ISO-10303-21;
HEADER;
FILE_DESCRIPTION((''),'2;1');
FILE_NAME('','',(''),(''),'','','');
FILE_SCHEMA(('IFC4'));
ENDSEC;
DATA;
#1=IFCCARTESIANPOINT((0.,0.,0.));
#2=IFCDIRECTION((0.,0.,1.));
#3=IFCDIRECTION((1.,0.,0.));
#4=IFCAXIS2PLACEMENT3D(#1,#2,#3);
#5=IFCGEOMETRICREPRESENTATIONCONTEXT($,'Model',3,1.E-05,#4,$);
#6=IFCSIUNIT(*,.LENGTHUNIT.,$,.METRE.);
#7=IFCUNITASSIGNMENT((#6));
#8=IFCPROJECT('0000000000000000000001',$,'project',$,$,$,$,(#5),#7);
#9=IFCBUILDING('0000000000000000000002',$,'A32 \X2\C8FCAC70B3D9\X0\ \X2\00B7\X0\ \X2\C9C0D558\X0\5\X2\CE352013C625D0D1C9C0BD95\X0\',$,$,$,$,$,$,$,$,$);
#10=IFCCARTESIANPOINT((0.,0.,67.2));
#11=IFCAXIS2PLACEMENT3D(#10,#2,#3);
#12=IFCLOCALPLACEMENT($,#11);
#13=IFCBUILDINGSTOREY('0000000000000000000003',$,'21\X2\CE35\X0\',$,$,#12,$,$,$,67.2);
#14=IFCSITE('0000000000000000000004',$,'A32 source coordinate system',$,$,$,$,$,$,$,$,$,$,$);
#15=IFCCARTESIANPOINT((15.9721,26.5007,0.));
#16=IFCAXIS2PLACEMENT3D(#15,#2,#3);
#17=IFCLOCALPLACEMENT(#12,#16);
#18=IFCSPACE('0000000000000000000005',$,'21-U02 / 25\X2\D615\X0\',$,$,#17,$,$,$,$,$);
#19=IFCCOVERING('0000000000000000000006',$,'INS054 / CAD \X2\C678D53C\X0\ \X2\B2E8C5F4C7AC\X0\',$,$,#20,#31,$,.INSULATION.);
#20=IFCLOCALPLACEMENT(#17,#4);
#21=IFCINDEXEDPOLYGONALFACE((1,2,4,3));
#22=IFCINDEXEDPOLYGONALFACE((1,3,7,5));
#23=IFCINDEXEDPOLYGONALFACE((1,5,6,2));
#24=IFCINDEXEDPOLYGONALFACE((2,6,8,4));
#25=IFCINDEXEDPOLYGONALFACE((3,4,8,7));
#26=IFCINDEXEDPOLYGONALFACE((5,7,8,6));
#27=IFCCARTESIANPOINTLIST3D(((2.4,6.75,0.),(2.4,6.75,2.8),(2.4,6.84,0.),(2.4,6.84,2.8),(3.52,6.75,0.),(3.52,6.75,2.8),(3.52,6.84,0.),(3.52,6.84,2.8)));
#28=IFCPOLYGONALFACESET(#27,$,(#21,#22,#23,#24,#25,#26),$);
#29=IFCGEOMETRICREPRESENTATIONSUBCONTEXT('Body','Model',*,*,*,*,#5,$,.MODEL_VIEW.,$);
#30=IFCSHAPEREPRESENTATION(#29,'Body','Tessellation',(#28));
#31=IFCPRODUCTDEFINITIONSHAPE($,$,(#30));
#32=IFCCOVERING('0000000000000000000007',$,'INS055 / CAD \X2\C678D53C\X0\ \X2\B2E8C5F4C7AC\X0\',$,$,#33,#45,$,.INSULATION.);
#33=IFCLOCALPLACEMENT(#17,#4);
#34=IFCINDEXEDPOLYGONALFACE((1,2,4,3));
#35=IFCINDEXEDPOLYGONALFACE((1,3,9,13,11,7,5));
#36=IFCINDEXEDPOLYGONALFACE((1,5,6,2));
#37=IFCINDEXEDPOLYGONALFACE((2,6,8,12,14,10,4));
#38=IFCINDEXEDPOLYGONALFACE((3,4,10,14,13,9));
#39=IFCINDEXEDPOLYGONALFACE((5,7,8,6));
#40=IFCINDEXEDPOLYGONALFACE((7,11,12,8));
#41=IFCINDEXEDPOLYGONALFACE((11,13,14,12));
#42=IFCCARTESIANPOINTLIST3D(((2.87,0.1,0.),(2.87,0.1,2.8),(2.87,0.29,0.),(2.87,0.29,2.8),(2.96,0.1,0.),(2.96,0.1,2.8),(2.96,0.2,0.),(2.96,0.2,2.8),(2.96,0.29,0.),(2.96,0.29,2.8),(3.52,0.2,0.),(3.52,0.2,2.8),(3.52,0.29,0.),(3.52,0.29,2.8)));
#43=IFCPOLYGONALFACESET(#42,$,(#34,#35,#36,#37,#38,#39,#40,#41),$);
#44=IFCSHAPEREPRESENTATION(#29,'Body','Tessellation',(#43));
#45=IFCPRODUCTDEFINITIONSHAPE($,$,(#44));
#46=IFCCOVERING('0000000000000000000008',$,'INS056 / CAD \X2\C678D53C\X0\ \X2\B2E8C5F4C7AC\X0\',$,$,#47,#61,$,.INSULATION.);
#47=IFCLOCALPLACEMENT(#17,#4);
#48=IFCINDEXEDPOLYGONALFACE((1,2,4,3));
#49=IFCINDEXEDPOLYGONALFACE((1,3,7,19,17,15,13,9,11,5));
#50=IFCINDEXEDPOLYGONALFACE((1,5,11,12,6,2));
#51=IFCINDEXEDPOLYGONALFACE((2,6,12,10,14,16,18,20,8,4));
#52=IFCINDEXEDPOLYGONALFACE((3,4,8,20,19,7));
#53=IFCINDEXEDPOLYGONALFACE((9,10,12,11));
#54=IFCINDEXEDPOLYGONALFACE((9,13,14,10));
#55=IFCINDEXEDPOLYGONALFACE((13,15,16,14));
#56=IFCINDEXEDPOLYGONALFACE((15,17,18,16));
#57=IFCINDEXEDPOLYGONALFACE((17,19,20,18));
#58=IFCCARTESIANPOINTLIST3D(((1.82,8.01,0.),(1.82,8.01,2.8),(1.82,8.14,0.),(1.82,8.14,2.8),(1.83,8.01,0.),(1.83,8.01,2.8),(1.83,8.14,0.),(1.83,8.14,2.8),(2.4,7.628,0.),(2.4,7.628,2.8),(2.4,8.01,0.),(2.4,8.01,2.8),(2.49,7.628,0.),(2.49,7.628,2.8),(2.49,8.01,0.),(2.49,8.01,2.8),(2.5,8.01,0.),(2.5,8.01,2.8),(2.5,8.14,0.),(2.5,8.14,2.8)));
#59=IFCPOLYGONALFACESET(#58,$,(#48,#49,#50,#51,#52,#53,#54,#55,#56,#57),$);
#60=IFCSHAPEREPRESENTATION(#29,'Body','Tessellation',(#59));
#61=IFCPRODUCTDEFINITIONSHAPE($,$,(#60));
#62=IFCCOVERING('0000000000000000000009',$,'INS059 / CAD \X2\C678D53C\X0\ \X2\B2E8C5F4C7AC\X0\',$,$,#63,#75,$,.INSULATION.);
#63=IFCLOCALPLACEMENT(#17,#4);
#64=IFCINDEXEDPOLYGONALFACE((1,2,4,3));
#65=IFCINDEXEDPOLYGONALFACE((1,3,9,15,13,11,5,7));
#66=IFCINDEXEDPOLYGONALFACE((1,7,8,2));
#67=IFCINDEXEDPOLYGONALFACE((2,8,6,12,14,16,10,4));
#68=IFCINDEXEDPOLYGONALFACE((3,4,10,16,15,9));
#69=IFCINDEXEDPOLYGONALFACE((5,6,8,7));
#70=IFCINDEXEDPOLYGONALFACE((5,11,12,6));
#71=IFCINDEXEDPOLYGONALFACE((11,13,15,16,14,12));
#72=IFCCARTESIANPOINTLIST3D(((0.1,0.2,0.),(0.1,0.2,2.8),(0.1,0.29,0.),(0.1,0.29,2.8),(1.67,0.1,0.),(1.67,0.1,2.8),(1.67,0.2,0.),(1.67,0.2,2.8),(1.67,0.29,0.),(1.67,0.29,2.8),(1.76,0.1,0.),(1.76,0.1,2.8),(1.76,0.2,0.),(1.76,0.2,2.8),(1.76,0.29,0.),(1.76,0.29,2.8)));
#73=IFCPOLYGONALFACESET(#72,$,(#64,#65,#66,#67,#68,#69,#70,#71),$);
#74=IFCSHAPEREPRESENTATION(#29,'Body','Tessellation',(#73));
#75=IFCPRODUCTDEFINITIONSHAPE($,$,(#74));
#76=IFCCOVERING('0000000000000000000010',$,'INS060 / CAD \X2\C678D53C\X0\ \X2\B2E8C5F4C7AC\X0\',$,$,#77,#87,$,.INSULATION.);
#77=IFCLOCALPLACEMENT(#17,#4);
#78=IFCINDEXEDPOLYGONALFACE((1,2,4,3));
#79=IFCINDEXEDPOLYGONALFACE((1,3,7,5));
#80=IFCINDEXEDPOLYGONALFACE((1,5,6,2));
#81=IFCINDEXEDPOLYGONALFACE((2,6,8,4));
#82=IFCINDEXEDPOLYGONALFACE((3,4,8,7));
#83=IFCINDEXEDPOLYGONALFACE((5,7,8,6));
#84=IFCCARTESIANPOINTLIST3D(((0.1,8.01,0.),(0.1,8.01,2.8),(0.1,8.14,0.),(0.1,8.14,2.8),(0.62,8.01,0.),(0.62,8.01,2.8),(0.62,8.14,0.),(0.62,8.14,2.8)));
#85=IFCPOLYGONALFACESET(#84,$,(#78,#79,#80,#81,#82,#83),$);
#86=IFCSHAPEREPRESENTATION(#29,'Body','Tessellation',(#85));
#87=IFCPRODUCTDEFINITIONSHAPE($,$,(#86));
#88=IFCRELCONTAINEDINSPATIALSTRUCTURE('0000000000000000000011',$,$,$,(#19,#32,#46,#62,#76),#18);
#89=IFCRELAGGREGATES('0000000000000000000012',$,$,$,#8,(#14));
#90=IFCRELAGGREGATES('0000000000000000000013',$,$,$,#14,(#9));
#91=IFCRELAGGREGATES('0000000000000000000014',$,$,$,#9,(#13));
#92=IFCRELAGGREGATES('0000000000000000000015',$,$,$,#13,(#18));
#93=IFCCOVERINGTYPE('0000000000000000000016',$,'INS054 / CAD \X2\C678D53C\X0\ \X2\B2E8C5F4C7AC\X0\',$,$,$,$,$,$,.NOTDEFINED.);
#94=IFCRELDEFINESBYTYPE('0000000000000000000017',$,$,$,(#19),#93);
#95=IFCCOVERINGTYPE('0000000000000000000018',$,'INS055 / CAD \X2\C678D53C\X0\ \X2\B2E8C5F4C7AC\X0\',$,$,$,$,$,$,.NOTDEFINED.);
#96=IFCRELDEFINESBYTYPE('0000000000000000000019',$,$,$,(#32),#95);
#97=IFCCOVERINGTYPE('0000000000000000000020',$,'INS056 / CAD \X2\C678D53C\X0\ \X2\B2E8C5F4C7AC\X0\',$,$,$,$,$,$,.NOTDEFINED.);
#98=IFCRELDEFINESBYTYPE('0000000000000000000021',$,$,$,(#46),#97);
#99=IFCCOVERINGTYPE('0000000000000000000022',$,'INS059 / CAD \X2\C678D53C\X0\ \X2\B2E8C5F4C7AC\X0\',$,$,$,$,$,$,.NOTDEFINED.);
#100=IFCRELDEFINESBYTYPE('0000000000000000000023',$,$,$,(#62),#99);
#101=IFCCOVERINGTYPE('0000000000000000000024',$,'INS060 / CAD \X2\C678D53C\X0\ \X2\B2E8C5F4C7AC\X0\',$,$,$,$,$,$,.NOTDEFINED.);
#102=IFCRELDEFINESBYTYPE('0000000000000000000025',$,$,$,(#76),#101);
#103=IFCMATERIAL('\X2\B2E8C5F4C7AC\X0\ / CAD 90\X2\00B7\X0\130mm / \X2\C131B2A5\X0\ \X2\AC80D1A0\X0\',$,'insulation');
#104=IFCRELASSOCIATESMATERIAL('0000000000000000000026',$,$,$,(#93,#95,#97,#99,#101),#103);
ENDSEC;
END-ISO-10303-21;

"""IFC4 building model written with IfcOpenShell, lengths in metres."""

from ifc_helpers import new_model, si_unit, frame, origin, origin_with_axes, place, context, subcontext, project, spatial, polyline, outline, extrude, source, transform, mapped, material, type_object, type_shapes, element, save


model = new_model("IFC4")

# Units and contexts
model_context = context("Model", 3, precision=1e-05, world=origin_with_axes())
body_context = subcontext(model_context, "Body", "Model", "MODEL_VIEW")
ifc_project = project(units=[si_unit("LENGTHUNIT", "METRE")], contexts=[model_context])

# Site, building, storey, space
storey_placement = place(None, frame((0.0, 0.0, 67.2), z_axis=(0.0, 0.0, 1.0), x_axis=(1.0, 0.0, 0.0)))
space_placement = place(storey_placement, frame((15.9721, 26.5007, 0.0), z_axis=(0.0, 0.0, 1.0), x_axis=(1.0, 0.0, 0.0)))
site = spatial("IfcSite", under=ifc_project, Name="A32 source coordinate system")
building = spatial("IfcBuilding", under=site, Name="A32 주거동 · 지하5층–옥탑지붕")
storey = spatial("IfcBuildingStorey", under=building, at=storey_placement, Name="21층", Elevation=67.2)
space = spatial("IfcSpace", under=storey, at=space_placement, Name="21-U02 / 25형")

# Coverings
ifc_material = material(Name="단열재 / CAD 90·130mm / 성능 검토", Category="insulation")
covering_type_1 = type_object("IfcCoveringType", Name="INS054 / CAD 외피 단열재", PredefinedType="NOTDEFINED", material=ifc_material)
shared_shape_1 = source(origin(), body_context, "Body", "SweptSolid", [
    extrude(outline(polyline([(2.4, 6.84), (3.52, 6.84), (3.52, 6.75), (2.4, 6.75), (2.4, 6.84)])), origin(), (0.0, 0.0, 1.0), 2.8),
])
type_shapes(covering_type_1, [shared_shape_1])
covering_1_placement = place(space_placement, origin_with_axes())
element("IfcCovering", 1, at=covering_1_placement, inside=space, type_object=covering_type_1, Name="INS054 / CAD 외피 단열재", PredefinedType="INSULATION", context=body_context, shape_type="MappedRepresentation", body=[
    mapped(shared_shape_1, transform((0.0, 0.0, 0.0), scale=1.0)),
])
covering_type_2 = type_object("IfcCoveringType", Name="INS055 / CAD 외피 단열재", PredefinedType="NOTDEFINED", material=ifc_material)
shared_shape_2 = source(origin(), body_context, "Body", "SweptSolid", [
    extrude(outline(polyline([(2.87, 0.29), (2.96, 0.29), (3.52, 0.29), (3.52, 0.2), (2.96, 0.2), (2.96, 0.1), (2.87, 0.1), (2.87, 0.29)])), origin(), (0.0, 0.0, 1.0), 2.8),
])
type_shapes(covering_type_2, [shared_shape_2])
covering_2_placement = place(space_placement, origin_with_axes())
element("IfcCovering", 2, at=covering_2_placement, inside=space, type_object=covering_type_2, Name="INS055 / CAD 외피 단열재", PredefinedType="INSULATION", context=body_context, shape_type="MappedRepresentation", body=[
    mapped(shared_shape_2, transform((0.0, 0.0, 0.0), scale=1.0)),
])
covering_type_3 = type_object("IfcCoveringType", Name="INS056 / CAD 외피 단열재", PredefinedType="NOTDEFINED", material=ifc_material)
shared_shape_3 = source(origin(), body_context, "Body", "SweptSolid", [
    extrude(outline(polyline([(2.49, 7.628), (2.4, 7.628), (2.4, 8.01), (1.83, 8.01), (1.82, 8.01), (1.82, 8.14), (1.83, 8.14), (2.5, 8.14), (2.5, 8.01), (2.49, 8.01), (2.49, 7.628)])), origin(), (0.0, 0.0, 1.0), 2.8),
])
type_shapes(covering_type_3, [shared_shape_3])
covering_3_placement = place(space_placement, origin_with_axes())
element("IfcCovering", 3, at=covering_3_placement, inside=space, type_object=covering_type_3, Name="INS056 / CAD 외피 단열재", PredefinedType="INSULATION", context=body_context, shape_type="MappedRepresentation", body=[
    mapped(shared_shape_3, transform((0.0, 0.0, 0.0), scale=1.0)),
])
covering_type_4 = type_object("IfcCoveringType", Name="INS059 / CAD 외피 단열재", PredefinedType="NOTDEFINED", material=ifc_material)
shared_shape_4 = source(origin(), body_context, "Body", "SweptSolid", [
    extrude(outline(polyline([(1.76, 0.1), (1.67, 0.1), (1.67, 0.2), (0.1, 0.2), (0.1, 0.29), (1.67, 0.29), (1.76, 0.29), (1.76, 0.2), (1.76, 0.1)])), origin(), (0.0, 0.0, 1.0), 2.8),
])
type_shapes(covering_type_4, [shared_shape_4])
covering_4_placement = place(space_placement, origin_with_axes())
element("IfcCovering", 4, at=covering_4_placement, inside=space, type_object=covering_type_4, Name="INS059 / CAD 외피 단열재", PredefinedType="INSULATION", context=body_context, shape_type="MappedRepresentation", body=[
    mapped(shared_shape_4, transform((0.0, 0.0, 0.0), scale=1.0)),
])
covering_type_5 = type_object("IfcCoveringType", Name="INS060 / CAD 외피 단열재", PredefinedType="NOTDEFINED", material=ifc_material)
shared_shape_5 = source(origin(), body_context, "Body", "SweptSolid", [
    extrude(outline(polyline([(0.1, 8.01), (0.1, 8.14), (0.62, 8.14), (0.62, 8.01), (0.1, 8.01)])), origin(), (0.0, 0.0, 1.0), 2.8),
])
type_shapes(covering_type_5, [shared_shape_5])
covering_5_placement = place(space_placement, origin_with_axes())
element("IfcCovering", 5, at=covering_5_placement, inside=space, type_object=covering_type_5, Name="INS060 / CAD 외피 단열재", PredefinedType="INSULATION", context=body_context, shape_type="MappedRepresentation", body=[
    mapped(shared_shape_5, transform((0.0, 0.0, 0.0), scale=1.0)),
])

save(model, "model.ifc")
